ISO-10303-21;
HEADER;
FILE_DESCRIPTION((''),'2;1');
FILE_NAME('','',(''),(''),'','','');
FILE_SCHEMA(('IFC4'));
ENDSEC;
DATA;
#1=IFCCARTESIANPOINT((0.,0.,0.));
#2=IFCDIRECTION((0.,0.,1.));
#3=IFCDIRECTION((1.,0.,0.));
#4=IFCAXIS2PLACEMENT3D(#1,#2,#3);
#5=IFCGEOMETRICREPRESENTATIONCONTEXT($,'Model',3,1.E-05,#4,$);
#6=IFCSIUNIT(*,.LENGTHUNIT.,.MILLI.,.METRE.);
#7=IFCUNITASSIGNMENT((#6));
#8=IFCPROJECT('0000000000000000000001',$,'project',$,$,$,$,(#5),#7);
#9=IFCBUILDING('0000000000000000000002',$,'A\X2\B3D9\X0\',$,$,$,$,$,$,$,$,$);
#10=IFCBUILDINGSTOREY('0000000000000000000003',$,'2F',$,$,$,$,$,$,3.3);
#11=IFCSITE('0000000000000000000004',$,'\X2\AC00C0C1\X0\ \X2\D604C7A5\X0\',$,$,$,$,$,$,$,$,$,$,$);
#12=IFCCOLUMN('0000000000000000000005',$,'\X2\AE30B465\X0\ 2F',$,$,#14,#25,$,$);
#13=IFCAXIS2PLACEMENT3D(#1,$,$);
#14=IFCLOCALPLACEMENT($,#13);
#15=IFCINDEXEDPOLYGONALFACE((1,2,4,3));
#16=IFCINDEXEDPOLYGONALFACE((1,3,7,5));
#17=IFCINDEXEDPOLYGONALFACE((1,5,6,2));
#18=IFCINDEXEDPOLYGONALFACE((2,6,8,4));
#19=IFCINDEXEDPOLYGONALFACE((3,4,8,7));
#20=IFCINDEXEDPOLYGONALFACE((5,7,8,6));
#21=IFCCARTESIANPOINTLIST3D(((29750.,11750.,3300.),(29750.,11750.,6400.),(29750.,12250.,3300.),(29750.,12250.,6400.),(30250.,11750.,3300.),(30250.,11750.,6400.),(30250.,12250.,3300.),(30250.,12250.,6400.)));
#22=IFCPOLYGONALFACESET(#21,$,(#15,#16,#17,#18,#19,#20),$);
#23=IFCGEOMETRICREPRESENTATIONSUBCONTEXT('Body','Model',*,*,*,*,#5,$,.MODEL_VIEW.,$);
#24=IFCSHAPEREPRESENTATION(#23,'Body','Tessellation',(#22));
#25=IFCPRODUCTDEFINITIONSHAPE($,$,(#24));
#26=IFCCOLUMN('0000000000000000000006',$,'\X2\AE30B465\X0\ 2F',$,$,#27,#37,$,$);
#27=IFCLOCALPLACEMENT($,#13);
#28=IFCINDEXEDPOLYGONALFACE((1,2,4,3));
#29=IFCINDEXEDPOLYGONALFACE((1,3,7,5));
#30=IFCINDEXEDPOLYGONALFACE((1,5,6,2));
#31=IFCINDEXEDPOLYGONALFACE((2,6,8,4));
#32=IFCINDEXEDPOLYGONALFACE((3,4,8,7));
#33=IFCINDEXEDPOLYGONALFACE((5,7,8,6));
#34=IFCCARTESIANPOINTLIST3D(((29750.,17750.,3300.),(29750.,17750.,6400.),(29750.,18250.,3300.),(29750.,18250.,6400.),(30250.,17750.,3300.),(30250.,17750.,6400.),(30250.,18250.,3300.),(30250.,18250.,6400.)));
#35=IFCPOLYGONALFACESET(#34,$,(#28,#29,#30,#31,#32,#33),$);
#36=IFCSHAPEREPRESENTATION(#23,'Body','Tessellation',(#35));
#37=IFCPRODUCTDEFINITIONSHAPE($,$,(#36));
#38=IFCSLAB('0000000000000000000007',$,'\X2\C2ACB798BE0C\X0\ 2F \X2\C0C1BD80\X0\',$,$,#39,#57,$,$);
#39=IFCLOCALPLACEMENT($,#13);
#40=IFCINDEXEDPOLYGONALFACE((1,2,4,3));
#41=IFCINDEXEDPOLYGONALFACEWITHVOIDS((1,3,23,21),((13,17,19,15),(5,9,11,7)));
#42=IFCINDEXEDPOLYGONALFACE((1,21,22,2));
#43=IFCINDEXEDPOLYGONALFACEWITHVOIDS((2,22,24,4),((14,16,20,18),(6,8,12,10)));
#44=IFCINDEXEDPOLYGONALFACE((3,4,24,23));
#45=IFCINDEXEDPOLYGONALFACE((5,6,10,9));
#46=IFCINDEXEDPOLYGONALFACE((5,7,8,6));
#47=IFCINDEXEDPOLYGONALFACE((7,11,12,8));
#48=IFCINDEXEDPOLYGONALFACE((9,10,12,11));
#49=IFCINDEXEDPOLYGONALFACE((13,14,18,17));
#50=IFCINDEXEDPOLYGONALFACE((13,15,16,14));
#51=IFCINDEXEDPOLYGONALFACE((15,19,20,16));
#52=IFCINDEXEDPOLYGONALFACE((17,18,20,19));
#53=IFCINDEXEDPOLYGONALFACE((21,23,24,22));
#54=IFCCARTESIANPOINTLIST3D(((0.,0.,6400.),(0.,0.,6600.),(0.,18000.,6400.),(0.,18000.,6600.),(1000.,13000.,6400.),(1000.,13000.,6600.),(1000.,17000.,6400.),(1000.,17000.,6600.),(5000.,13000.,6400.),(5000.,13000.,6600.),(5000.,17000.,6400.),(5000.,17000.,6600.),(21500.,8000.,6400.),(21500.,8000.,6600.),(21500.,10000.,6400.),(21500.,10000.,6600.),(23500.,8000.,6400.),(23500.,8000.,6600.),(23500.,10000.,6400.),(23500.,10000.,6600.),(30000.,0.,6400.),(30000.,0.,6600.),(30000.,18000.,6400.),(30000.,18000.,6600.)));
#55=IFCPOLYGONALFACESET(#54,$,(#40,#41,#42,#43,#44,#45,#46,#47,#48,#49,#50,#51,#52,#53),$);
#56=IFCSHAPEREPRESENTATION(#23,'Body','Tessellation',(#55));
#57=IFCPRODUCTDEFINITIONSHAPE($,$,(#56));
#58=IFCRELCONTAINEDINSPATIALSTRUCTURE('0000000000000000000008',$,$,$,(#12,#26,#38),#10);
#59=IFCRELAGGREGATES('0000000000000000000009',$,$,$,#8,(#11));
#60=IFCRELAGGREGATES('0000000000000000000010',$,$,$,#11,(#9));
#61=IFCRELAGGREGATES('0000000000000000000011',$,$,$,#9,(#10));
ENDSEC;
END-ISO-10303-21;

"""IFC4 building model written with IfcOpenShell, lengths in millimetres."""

from ifc_helpers import new_model, si_unit, frame, origin_with_axes, place, context, subcontext, project, spatial, indexed_curve, outline, extrude, element, save


model = new_model("IFC4")

# Units and contexts
model_context = context("Model", 3, precision=1e-05, world=origin_with_axes())
body_context = subcontext(model_context, "Body", "Model", "MODEL_VIEW")
ifc_project = project(units=[si_unit("LENGTHUNIT", "METRE", prefix="MILLI")], contexts=[model_context])

# Site, building, storey
site = spatial("IfcSite", under=ifc_project, Name="가상 현장")
building = spatial("IfcBuilding", under=site, Name="A동")
storey = spatial("IfcBuildingStorey", under=building, Name="2F", Elevation=3.3)

# Columns
for number, where, z_axis, x_axis, name in (
    (1, (29750.0, 11750.0, 3300.0), (0.0, 0.0, 1.0), (1.0, 0.0, 0.0), "기둥 2F"),
    (2, (29750.0, 17750.0, 3300.0), (0.0, 0.0, 1.0), (1.0, 0.0, 0.0), "기둥 2F"),
):
    element("IfcColumn", number, at=place(None, frame(where, z_axis=z_axis, x_axis=x_axis)), inside=storey, Name=name, context=body_context, shape_type="SweptSolid", body=[
        extrude(outline(indexed_curve([(0.0, 0.0), (0.0, 500.0), (500.0, 500.0), (500.0, 0.0), (0.0, 0.0)], self_intersect=False)), origin_with_axes(), (0.0, 0.0, 1.0), 3100.0),
    ])

# Slab, openings
slab_placement = place(None, frame((0.0, 0.0, 6400.0), z_axis=(0.0, 0.0, 1.0), x_axis=(1.0, 0.0, 0.0)))
slab = element("IfcSlab", 3, at=slab_placement, inside=storey, Name="슬래브 2F 상부", context=body_context, shape_type="SweptSolid", body=[
    extrude(outline(indexed_curve([(0.0, 0.0), (30000.0, 0.0), (30000.0, 18000.0), (0.0, 18000.0)])), None, (0.0, 0.0, 1.0), 200.0),
])
opening_1_placement = place(slab_placement, frame((1000.0, 13000.0, -10.0), z_axis=(0.0, 0.0, 1.0), x_axis=(1.0, 0.0, 0.0)))
element("IfcOpeningElement", 4, at=opening_1_placement, cuts=slab, context=body_context, shape_type="SweptSolid", body=[
    extrude(outline(indexed_curve([(0.0, 0.0), (4000.0, 0.0), (4000.0, 4000.0), (0.0, 4000.0)])), None, (0.0, 0.0, 1.0), 220.0),
])
opening_2_placement = place(slab_placement, frame((21500.0, 8000.0, -10.0), z_axis=(0.0, 0.0, 1.0), x_axis=(1.0, 0.0, 0.0)))
element("IfcOpeningElement", 5, at=opening_2_placement, cuts=slab, context=body_context, shape_type="SweptSolid", body=[
    extrude(outline(indexed_curve([(0.0, 0.0), (2000.0, 0.0), (2000.0, 2000.0), (0.0, 2000.0)])), None, (0.0, 0.0, 1.0), 220.0),
])

save(model, "model.ifc")
